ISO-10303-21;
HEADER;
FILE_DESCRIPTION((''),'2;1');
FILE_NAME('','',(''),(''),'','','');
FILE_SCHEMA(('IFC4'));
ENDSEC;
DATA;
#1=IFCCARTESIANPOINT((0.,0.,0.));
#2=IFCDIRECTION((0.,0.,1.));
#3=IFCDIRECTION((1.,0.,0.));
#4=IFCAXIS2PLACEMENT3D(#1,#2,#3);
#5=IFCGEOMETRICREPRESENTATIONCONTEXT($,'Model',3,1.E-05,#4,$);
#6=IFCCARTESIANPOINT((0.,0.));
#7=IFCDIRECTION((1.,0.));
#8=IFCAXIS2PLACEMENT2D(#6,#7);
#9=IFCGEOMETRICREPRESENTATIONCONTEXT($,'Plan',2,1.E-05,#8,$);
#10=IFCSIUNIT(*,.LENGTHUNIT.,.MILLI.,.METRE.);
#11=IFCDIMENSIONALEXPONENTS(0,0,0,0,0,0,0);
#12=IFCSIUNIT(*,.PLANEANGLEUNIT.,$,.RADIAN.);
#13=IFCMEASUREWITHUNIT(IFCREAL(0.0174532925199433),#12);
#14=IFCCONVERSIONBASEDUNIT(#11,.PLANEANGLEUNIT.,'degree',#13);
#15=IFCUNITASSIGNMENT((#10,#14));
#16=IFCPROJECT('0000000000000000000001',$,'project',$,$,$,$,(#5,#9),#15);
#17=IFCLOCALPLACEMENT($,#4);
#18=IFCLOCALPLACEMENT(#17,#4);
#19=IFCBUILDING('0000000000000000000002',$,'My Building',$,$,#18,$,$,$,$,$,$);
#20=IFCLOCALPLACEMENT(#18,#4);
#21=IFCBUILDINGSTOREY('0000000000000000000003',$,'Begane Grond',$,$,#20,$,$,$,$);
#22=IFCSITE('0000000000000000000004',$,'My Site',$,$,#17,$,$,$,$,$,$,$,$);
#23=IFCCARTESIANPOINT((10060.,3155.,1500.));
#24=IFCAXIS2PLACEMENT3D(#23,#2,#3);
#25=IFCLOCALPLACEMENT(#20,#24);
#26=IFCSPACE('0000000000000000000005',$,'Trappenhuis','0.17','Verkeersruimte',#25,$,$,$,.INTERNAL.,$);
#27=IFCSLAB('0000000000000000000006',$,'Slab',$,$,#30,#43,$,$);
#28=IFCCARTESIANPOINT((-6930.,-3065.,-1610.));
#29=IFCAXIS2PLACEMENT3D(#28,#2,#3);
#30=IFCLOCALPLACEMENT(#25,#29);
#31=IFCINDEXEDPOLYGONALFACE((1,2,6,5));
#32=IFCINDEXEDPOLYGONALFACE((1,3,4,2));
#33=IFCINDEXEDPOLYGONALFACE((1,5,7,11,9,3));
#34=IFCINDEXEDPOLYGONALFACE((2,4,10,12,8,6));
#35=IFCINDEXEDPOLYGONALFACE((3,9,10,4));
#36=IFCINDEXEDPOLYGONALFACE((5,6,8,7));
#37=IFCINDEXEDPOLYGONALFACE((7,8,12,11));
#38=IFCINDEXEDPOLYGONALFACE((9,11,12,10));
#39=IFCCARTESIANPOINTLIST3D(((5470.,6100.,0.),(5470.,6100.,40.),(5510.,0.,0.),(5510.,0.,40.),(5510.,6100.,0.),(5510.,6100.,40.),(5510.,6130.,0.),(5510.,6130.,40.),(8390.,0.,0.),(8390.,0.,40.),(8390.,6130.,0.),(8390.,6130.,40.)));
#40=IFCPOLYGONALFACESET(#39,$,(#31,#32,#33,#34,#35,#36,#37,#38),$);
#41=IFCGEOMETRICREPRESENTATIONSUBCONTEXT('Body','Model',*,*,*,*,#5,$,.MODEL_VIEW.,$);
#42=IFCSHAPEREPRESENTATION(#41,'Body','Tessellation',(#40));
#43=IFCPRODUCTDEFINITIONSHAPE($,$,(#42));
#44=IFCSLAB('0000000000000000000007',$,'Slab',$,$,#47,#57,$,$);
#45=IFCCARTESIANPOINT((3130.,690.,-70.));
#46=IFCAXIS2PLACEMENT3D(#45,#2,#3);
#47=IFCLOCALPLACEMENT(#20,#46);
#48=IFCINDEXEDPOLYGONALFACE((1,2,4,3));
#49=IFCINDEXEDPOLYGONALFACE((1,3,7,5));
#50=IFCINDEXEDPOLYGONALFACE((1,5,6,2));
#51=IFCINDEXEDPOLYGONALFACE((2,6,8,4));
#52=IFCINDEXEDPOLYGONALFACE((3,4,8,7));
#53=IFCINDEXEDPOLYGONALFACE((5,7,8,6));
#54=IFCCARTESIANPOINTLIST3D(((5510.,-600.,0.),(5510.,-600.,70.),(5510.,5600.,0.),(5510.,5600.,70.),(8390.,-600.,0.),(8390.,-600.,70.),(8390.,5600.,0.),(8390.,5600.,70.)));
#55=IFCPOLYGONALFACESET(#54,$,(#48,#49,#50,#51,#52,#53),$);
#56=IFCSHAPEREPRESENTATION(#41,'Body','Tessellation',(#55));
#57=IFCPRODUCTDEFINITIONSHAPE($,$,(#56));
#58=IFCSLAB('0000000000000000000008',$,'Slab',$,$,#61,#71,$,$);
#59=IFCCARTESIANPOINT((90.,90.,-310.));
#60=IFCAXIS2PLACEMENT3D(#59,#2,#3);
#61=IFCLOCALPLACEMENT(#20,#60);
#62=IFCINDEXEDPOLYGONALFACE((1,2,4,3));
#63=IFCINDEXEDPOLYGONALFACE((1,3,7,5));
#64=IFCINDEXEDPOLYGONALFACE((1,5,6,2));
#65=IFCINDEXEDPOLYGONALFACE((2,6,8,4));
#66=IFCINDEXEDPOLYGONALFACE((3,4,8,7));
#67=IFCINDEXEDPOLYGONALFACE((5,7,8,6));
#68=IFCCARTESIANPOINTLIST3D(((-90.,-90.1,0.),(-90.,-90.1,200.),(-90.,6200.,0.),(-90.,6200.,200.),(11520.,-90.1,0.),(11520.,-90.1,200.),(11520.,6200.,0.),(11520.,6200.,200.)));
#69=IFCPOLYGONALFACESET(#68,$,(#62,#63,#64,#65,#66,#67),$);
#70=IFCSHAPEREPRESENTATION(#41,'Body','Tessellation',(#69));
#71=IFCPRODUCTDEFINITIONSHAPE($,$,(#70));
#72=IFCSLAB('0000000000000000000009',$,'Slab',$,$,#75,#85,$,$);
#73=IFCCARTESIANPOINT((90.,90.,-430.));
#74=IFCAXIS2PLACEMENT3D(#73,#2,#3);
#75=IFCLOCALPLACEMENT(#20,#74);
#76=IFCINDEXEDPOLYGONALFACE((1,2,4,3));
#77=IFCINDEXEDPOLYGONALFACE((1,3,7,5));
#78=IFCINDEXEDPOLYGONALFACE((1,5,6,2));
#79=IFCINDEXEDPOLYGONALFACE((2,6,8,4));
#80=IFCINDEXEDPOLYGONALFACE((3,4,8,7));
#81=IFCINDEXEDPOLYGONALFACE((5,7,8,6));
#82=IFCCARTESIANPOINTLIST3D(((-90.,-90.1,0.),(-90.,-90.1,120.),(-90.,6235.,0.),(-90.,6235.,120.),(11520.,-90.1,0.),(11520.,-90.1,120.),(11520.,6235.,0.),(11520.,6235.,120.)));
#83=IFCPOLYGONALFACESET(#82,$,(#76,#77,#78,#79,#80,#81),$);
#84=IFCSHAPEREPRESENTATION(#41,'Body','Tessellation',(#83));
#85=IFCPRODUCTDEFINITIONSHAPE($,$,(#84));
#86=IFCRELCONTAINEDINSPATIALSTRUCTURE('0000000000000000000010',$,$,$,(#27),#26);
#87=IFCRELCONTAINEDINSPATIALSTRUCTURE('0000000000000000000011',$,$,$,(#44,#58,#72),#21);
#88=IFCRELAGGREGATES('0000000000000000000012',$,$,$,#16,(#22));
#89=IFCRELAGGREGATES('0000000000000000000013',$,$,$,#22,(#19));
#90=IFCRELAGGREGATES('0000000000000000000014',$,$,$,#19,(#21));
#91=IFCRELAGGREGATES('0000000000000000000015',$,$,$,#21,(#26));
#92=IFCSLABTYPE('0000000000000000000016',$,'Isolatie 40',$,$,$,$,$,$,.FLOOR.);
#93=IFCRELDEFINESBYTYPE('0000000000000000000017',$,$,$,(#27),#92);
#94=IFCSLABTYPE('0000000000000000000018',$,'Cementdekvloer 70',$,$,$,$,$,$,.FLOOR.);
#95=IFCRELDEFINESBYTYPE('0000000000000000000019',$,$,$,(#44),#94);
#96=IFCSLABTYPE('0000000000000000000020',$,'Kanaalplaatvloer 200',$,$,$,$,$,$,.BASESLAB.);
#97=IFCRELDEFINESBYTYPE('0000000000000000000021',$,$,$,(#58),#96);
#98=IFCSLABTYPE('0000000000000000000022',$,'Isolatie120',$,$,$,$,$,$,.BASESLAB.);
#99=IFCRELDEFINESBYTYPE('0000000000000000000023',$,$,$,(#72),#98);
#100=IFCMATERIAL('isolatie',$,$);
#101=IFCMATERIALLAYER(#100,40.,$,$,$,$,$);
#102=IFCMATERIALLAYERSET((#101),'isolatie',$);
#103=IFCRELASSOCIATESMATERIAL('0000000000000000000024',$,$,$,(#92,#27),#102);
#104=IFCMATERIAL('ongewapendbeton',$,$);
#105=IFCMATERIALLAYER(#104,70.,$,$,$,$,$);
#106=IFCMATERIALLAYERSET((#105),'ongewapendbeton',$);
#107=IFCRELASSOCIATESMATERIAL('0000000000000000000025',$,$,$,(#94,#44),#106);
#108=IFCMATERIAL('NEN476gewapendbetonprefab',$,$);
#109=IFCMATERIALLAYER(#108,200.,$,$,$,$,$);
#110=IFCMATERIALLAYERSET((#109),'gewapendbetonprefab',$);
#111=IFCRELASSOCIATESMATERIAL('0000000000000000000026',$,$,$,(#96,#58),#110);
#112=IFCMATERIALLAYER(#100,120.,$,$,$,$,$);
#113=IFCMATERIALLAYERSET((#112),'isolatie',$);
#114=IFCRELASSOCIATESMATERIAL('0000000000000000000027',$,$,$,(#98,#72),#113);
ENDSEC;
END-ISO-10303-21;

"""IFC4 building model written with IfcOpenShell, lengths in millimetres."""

from ifc_helpers import new_model, entity, si_unit, converted_unit, frame, origin_with_axes, origin_2d_with_axis, place, context, subcontext, project, spatial, line, indexed_curve, outline, extrude, material, layer, layer_set, layer_usage, type_object, element, save


model = new_model("IFC4")

# Units and contexts
model_context = context("Model", 3, precision=1e-05, world=origin_with_axes())
plan_context = context("Plan", 2, precision=1e-05, world=origin_2d_with_axis())
body_context = subcontext(model_context, "Body", "Model", "MODEL_VIEW")
ifc_project = project(units=[si_unit("LENGTHUNIT", "METRE", prefix="MILLI"), converted_unit("PLANEANGLEUNIT", "degree", entity("IfcReal", 0.0174532925199433), si_unit("PLANEANGLEUNIT", "RADIAN"), dimensions=[0, 0, 0, 0, 0, 0, 0])], contexts=[model_context, plan_context])

# Site, building, storey, space
site_placement = place(None, origin_with_axes())
site = spatial("IfcSite", under=ifc_project, at=site_placement, Name="My Site")
building_placement = place(site_placement, origin_with_axes())
building = spatial("IfcBuilding", under=site, at=building_placement, Name="My Building")
storey_placement = place(building_placement, origin_with_axes())
storey = spatial("IfcBuildingStorey", under=building, at=storey_placement, Name="Begane Grond")
space_1_placement = place(storey_placement, frame((10060.0, 3155.0, 1500.0), z_axis=(0.0, 0.0, 1.0), x_axis=(1.0, 0.0, 0.0)))
space_1 = spatial("IfcSpace", under=storey, at=space_1_placement, Name="Trappenhuis", Description="0.17", ObjectType="Verkeersruimte", PredefinedType="INTERNAL")

# Shared definitions
ifc_material_1 = material(Name="NEN476gewapendbetonprefab")

# Slab
ifc_material_2 = material(Name="isolatie")
ifc_layer_1 = layer(ifc_material_2, 40.0)
ifc_layer_set_1 = layer_set([ifc_layer_1], Name="isolatie")
ifc_layer_usage_1 = layer_usage(ifc_layer_set_1, "AXIS3", "POSITIVE", 0.0)
slab_type_1 = type_object("IfcSlabType", Name="Isolatie 40", PredefinedType="FLOOR", material=ifc_layer_set_1)
slab_1_placement = place(space_1_placement, frame((-6930.0, -3065.0, -1610.0), z_axis=(0.0, 0.0, 1.0), x_axis=(1.0, 0.0, 0.0)))
element("IfcSlab", 1, at=slab_1_placement, inside=space_1, type_object=slab_type_1, material=ifc_layer_usage_1, Name="Slab", context=body_context, shape_type="SweptSolid", body=[
    extrude(outline(indexed_curve([(8390.0, 0.0), (5510.0, 0.0), (5510.0, 6130.0), (5470.0, 6100.0), (5510.0, 6100.0), (8390.0, 6130.0)], segments=[line(2, 1), line(1, 6), line(6, 3), line(3, 5), line(5, 4), line(4, 2)], self_intersect=False)), None, (0.0, 0.0, 1.0), 40.0),
])

# Slabs
ifc_material_3 = material(Name="ongewapendbeton")
ifc_layer_2 = layer(ifc_material_3, 70.0)
ifc_layer_set_2 = layer_set([ifc_layer_2], Name="ongewapendbeton")
slab_type_2 = type_object("IfcSlabType", Name="Cementdekvloer 70", PredefinedType="FLOOR", material=ifc_layer_set_2)
ifc_layer_usage_2 = layer_usage(ifc_layer_set_2, "AXIS3", "POSITIVE", 0.0)
slab_2_placement = place(storey_placement, frame((3130.0, 690.0, -70.0), z_axis=(0.0, 0.0, 1.0), x_axis=(1.0, 0.0, 0.0)))
element("IfcSlab", 2, at=slab_2_placement, inside=storey, type_object=slab_type_2, material=ifc_layer_usage_2, Name="Slab", context=body_context, shape_type="SweptSolid", body=[
    extrude(outline(indexed_curve([(8390.0, 5600.0), (8390.0, -600.0), (5510.0, -600.0), (5510.0, 5600.0)], segments=[line(1, 4), line(4, 3), line(3, 2), line(2, 1)], self_intersect=False)), None, (0.0, 0.0, 1.0), 70.0),
])
ifc_layer_3 = layer(ifc_material_1, 200.0)
ifc_layer_set_3 = layer_set([ifc_layer_3], Name="gewapendbetonprefab")
ifc_layer_usage_3 = layer_usage(ifc_layer_set_3, "AXIS3", "POSITIVE", 0.0)
slab_type_3 = type_object("IfcSlabType", Name="Kanaalplaatvloer 200", PredefinedType="BASESLAB", material=ifc_layer_set_3)
slab_3_placement = place(storey_placement, frame((90.0, 90.0, -310.0), z_axis=(0.0, 0.0, 1.0), x_axis=(1.0, 0.0, 0.0)))
element("IfcSlab", 3, at=slab_3_placement, inside=storey, type_object=slab_type_3, material=ifc_layer_usage_3, Name="Slab", context=body_context, shape_type="SweptSolid", body=[
    extrude(outline(indexed_curve([(-90.0, -90.1), (11520.0, -90.1), (11520.0, 6200.0), (-90.0, 6200.0)], segments=[line(4, 1), line(1, 2), line(2, 3), line(3, 4)], self_intersect=False)), None, (0.0, 0.0, 1.0), 200.0),
])
ifc_layer_4 = layer(ifc_material_2, 120.0)
ifc_layer_set_4 = layer_set([ifc_layer_4], Name="isolatie")
ifc_layer_usage_4 = layer_usage(ifc_layer_set_4, "AXIS3", "POSITIVE", 0.0)
slab_type_4 = type_object("IfcSlabType", Name="Isolatie120", PredefinedType="BASESLAB", material=ifc_layer_set_4)
slab_4_placement = place(storey_placement, frame((90.0, 90.0, -430.0), z_axis=(0.0, 0.0, 1.0), x_axis=(1.0, 0.0, 0.0)))
element("IfcSlab", 4, at=slab_4_placement, inside=storey, type_object=slab_type_4, material=ifc_layer_usage_4, Name="Slab", context=body_context, shape_type="SweptSolid", body=[
    extrude(outline(indexed_curve([(11520.0, 6235.0), (-90.0, 6235.0), (-90.0, -90.1), (11520.0, -90.1)], segments=[line(4, 1), line(1, 2), line(2, 3), line(3, 4)], self_intersect=False)), None, (0.0, 0.0, 1.0), 120.0),
])

save(model, "model.ifc")
